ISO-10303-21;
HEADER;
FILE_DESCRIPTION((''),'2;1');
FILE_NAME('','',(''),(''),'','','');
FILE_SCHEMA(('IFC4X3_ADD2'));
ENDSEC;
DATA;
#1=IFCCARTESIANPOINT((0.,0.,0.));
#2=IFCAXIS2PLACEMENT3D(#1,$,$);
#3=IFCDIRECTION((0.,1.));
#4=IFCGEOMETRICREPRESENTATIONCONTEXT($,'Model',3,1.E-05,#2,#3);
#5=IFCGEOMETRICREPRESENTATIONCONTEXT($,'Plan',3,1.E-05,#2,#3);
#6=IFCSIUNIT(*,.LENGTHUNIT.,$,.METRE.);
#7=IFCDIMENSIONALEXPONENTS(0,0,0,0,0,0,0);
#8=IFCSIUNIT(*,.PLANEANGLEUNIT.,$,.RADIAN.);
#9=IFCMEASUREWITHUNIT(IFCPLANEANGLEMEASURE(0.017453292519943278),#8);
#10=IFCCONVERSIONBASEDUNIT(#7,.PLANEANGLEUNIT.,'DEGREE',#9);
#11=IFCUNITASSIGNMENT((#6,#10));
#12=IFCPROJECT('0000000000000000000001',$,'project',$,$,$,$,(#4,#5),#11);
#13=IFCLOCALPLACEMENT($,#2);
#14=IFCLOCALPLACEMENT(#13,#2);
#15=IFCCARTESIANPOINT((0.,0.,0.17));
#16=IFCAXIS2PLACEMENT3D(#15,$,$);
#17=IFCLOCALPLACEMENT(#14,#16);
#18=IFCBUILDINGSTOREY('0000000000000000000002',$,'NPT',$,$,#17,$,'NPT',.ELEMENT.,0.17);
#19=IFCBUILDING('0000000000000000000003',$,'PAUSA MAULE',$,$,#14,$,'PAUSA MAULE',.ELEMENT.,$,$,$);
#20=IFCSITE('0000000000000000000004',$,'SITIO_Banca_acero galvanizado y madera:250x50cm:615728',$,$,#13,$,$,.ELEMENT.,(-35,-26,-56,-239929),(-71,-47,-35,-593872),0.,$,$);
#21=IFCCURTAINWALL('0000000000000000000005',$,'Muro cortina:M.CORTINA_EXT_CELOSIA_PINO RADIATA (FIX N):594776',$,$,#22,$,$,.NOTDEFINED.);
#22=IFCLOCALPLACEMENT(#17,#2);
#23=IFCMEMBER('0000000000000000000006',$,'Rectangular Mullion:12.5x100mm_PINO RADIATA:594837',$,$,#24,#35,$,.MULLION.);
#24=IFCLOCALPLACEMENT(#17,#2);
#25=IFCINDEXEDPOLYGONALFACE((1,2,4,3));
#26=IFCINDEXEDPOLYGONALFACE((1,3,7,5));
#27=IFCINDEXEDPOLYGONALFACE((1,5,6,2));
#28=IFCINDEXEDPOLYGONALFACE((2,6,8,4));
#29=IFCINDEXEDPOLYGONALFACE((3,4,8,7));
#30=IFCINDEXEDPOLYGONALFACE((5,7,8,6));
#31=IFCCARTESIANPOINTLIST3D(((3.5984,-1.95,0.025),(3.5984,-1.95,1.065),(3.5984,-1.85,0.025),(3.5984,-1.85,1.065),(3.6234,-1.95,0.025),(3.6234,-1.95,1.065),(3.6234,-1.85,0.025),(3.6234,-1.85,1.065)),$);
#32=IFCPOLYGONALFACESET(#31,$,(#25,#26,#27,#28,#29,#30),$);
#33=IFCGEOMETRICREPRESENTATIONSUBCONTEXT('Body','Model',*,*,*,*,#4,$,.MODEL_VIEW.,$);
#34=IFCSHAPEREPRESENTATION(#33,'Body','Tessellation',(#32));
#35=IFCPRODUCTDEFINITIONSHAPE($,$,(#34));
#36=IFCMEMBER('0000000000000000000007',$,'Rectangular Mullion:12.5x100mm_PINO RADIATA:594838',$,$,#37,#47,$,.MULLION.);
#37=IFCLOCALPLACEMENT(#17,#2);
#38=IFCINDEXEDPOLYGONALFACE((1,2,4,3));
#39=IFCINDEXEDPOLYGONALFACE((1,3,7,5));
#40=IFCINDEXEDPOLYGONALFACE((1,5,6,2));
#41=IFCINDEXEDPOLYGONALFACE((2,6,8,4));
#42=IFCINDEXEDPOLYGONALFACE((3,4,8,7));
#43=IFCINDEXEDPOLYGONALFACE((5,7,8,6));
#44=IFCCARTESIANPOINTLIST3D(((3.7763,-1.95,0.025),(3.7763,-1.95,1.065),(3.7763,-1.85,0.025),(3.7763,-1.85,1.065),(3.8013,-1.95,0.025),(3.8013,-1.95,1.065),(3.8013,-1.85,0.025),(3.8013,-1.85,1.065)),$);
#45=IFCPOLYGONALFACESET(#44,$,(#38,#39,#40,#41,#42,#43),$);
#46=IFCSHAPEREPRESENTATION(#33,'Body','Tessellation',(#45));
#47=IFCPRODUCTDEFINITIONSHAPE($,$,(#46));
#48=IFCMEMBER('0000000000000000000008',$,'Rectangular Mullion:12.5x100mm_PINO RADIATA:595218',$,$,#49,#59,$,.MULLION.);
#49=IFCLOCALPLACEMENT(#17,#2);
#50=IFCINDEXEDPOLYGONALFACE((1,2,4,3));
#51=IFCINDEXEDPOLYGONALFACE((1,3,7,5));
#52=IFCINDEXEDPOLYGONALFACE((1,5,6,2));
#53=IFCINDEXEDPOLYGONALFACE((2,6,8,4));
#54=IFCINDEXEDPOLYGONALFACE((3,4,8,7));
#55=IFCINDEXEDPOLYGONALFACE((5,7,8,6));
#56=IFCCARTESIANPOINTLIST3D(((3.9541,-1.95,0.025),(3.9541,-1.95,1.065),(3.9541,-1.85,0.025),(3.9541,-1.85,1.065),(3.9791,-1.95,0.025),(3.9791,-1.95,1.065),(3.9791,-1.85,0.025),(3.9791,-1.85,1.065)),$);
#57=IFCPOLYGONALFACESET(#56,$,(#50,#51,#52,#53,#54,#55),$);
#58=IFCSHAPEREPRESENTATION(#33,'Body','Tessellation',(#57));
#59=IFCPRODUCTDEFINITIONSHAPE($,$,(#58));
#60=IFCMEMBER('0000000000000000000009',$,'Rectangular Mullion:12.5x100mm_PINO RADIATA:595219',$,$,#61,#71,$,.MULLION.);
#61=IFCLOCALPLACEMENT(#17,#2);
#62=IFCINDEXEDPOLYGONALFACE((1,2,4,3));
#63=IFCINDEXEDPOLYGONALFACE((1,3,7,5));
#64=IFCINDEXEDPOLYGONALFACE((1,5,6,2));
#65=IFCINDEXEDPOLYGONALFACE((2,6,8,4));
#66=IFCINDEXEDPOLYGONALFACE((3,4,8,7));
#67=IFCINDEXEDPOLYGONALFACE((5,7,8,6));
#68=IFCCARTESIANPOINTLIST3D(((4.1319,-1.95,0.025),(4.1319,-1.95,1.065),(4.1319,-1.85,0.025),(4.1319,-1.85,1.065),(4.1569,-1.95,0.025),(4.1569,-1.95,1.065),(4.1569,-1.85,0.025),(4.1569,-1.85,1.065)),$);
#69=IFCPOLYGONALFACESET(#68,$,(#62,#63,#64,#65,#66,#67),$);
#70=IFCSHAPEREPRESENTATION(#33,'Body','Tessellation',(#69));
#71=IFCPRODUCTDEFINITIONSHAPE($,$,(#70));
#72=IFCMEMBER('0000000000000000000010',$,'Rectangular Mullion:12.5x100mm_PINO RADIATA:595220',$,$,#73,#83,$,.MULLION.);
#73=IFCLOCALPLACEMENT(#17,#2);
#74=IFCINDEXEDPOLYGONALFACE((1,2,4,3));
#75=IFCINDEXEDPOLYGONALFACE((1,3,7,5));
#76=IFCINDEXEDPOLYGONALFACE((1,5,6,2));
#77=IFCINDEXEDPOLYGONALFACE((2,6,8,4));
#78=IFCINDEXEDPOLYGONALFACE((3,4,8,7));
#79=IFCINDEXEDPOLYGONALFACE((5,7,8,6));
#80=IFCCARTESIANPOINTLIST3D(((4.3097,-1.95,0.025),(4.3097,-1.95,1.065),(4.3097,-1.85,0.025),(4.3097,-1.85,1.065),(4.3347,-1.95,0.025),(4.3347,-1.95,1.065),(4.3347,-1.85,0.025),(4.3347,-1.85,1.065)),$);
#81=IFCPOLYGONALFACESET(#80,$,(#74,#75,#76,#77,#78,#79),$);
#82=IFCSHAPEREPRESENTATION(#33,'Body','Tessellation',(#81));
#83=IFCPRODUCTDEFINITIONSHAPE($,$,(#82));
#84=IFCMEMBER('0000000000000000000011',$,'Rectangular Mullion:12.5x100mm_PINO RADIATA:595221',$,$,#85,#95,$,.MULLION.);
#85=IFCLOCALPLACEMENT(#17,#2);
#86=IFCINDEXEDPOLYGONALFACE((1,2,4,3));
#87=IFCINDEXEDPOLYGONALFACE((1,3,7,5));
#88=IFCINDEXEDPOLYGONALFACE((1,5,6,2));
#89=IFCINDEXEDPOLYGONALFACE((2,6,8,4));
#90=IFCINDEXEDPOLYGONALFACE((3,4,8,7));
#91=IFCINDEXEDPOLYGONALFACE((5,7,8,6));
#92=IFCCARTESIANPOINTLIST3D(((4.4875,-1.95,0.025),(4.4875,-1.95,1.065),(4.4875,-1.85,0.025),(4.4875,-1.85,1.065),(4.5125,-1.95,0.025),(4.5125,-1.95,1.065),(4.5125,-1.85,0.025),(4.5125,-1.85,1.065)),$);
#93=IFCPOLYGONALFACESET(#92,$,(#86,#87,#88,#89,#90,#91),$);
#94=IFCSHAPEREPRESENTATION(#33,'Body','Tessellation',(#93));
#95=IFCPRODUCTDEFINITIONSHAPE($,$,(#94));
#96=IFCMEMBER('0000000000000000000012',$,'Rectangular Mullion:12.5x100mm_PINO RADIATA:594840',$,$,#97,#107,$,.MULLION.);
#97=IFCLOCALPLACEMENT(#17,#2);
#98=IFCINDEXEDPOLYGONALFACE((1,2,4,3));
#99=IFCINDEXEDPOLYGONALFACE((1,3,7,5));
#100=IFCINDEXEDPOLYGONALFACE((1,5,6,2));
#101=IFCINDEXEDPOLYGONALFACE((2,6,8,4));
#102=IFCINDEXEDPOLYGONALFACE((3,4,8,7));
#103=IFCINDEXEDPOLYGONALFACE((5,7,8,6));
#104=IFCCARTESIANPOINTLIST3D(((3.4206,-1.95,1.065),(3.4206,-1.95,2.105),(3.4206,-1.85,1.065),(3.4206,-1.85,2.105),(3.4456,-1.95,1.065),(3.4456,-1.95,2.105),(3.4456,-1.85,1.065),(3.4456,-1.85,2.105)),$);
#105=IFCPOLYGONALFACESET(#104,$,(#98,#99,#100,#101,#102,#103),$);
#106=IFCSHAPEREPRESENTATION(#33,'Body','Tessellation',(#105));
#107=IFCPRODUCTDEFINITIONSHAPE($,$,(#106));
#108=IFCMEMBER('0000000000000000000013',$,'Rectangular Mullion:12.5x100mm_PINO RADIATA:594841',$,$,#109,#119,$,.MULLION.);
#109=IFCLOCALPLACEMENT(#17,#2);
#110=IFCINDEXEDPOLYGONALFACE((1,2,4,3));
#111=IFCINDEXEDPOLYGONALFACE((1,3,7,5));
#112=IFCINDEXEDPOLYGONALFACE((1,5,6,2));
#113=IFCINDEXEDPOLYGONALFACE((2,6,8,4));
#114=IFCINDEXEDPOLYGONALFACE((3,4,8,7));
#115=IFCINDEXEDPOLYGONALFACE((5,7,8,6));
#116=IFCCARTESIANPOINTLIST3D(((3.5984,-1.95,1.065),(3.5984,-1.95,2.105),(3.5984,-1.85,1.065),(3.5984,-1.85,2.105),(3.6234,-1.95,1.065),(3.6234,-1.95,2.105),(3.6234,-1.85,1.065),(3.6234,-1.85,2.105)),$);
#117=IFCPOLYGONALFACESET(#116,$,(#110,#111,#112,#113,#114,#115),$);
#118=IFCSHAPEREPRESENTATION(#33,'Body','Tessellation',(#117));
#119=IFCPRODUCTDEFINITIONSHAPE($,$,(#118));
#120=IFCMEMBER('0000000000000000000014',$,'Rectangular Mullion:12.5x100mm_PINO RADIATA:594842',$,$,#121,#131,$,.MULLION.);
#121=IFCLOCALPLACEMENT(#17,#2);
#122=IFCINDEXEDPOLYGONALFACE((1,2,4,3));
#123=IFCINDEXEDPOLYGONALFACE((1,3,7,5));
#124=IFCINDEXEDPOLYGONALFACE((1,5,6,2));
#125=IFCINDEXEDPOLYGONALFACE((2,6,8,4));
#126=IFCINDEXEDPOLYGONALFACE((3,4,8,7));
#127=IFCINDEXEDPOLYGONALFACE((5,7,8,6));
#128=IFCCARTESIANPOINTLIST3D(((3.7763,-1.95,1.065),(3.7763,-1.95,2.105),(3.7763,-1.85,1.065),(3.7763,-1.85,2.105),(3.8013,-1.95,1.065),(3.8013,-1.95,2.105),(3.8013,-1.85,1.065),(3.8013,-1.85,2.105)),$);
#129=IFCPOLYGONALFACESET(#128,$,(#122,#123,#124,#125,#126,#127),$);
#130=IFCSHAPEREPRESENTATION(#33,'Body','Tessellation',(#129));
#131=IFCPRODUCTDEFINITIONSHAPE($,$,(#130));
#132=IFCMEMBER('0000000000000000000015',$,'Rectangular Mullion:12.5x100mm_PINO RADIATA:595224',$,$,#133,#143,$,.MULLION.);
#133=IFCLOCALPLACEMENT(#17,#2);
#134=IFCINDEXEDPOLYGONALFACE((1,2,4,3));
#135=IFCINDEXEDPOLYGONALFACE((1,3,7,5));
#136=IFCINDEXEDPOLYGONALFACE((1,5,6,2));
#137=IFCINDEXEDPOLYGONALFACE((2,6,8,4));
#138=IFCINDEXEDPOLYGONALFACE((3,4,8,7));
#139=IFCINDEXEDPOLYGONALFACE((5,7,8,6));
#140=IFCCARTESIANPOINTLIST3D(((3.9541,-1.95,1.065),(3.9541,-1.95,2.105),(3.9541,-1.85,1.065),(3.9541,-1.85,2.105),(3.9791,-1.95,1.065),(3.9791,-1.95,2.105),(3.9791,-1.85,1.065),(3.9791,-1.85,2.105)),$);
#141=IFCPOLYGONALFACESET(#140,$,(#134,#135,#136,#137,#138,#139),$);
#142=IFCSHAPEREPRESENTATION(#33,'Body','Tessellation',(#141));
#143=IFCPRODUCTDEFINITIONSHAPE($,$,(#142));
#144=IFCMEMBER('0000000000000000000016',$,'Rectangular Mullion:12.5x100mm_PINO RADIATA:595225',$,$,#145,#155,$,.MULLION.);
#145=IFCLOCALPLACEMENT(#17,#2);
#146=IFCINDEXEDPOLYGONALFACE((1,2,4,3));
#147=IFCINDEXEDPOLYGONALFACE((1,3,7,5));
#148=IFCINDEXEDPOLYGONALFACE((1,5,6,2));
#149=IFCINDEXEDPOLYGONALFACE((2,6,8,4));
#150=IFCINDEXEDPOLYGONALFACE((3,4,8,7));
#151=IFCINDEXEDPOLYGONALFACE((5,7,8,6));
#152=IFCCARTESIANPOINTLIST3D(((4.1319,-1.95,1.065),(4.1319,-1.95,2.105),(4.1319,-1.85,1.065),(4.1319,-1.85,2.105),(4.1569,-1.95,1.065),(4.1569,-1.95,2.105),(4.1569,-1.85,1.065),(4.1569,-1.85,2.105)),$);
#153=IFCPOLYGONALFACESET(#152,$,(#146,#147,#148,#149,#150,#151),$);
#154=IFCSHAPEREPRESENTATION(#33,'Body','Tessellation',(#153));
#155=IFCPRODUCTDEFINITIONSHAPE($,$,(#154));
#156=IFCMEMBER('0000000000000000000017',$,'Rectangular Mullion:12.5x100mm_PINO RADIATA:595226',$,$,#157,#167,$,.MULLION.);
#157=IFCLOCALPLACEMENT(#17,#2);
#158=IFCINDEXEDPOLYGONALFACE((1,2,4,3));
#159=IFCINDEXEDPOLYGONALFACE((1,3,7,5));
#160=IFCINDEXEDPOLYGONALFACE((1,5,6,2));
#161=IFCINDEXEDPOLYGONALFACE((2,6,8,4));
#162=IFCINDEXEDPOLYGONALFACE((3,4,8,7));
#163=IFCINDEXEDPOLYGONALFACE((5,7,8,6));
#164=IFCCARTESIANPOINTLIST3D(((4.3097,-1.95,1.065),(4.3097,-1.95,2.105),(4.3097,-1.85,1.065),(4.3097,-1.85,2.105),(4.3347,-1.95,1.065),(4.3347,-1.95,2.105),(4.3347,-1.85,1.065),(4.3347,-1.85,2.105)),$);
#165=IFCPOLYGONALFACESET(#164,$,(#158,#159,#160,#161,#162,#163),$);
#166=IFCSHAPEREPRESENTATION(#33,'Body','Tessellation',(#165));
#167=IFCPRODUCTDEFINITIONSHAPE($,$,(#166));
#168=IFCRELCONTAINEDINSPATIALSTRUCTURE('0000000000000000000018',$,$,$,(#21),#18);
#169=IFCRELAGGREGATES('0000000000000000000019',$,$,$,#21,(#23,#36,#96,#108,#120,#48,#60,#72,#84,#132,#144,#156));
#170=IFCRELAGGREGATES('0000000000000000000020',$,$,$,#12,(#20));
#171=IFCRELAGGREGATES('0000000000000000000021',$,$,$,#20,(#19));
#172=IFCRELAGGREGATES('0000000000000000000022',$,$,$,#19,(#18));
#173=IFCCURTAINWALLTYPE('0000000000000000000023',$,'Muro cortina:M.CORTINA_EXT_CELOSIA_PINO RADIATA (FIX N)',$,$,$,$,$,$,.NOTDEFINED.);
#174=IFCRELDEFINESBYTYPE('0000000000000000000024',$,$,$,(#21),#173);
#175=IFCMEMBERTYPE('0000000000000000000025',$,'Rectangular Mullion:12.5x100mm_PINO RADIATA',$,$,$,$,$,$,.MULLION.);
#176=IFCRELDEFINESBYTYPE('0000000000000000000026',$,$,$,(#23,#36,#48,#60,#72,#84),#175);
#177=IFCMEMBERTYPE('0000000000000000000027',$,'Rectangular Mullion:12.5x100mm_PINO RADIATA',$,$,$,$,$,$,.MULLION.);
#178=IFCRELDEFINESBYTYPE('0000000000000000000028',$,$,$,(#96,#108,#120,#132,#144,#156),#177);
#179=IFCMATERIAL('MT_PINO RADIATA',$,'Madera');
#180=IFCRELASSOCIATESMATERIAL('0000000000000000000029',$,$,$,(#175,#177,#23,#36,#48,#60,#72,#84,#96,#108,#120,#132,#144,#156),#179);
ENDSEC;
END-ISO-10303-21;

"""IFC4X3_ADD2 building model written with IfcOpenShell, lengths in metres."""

from ifc_helpers import new_model, entity, si_unit, converted_unit, direction, frame, frame_2d, origin, origin_2d_with_axis, place, context, subcontext, project, spatial, rectangle, extrude, source, transform, mapped, material, material_profile, profile_set, profile_usage, type_object, type_shapes, element, aggregate, save


model = new_model("IFC4X3_ADD2")

# Units and contexts
model_context = context("Model", 3, precision=1e-05, world=origin(), true_north=direction((0.0, 1.0)))
plan_context = context("Plan", 3, precision=1e-05, world=origin(), true_north=direction((0.0, 1.0)))
body_context = subcontext(model_context, "Body", "Model", "MODEL_VIEW")
ifc_project = project(units=[si_unit("LENGTHUNIT", "METRE"), converted_unit("PLANEANGLEUNIT", "DEGREE", entity("IfcPlaneAngleMeasure", 0.017453292519943278), si_unit("PLANEANGLEUNIT", "RADIAN"), dimensions=[0, 0, 0, 0, 0, 0, 0])], contexts=[model_context, plan_context])

# Site, building, storey
site_placement = place(None, origin())
site = spatial("IfcSite", under=ifc_project, at=site_placement, Name="SITIO_Banca_acero galvanizado y madera:250x50cm:615728", CompositionType="ELEMENT", RefLatitude=(-35, -26, -56, -239929), RefLongitude=(-71, -47, -35, -593872), RefElevation=0.0)
building_placement = place(site_placement, origin())
building = spatial("IfcBuilding", under=site, at=building_placement, Name="PAUSA MAULE", LongName="PAUSA MAULE", CompositionType="ELEMENT")
storey_placement = place(building_placement, frame((0.0, 0.0, 0.17)))
storey = spatial("IfcBuildingStorey", under=building, at=storey_placement, Name="NPT", LongName="NPT", CompositionType="ELEMENT", Elevation=0.17)

# Curtain wall, members
curtain_wall_type = type_object("IfcCurtainWallType", Name="Muro cortina:M.CORTINA_EXT_CELOSIA_PINO RADIATA (FIX N)", PredefinedType="NOTDEFINED")
curtain_wall_placement = place(storey_placement, frame((0.0, 0.0, -0.17)))
curtain_wall = element("IfcCurtainWall", 1, at=curtain_wall_placement, inside=storey, type_object=curtain_wall_type, Name="Muro cortina:M.CORTINA_EXT_CELOSIA_PINO RADIATA (FIX N):594776", PredefinedType="NOTDEFINED")
ifc_material = material(Name="MT_PINO RADIATA", Category="Madera")
ifc_material_profile = material_profile(ifc_material, rectangle(XDim=0.025, YDim=0.1, at=frame_2d((0.0, 0.0), x_axis=(1.0, 0.0))), Name="12.5x100mm_PINO RADIATA")
ifc_profile_set = profile_set([ifc_material_profile], Name="12.5x100mm_PINO RADIATA")
ifc_profile_usage = profile_usage(ifc_profile_set)
member_type_1 = type_object("IfcMemberType", Name="Rectangular Mullion:12.5x100mm_PINO RADIATA", PredefinedType="MULLION", material=ifc_profile_set)
shared_shape_1 = source(origin(), body_context, "Body", "SweptSolid", [
    extrude(rectangle(XDim=0.025, YDim=0.1, at=frame_2d((0.0, 0.0), x_axis=(1.0, 0.0))), frame((0.0, 0.0, -1.04), z_axis=(0.0, 0.0, 1.0), x_axis=(-1.0, 0.0, 0.0)), (0.0, 0.0, 1.0), 1.04),
])
type_shapes(member_type_1, [shared_shape_1])
member_1_placement = place(curtain_wall_placement, frame((3.6109, -1.9, 0.195), z_axis=(0.0, 0.0, -1.0), x_axis=(1.0, 0.0, 0.0)))
member_1 = element("IfcMember", 2, at=member_1_placement, type_object=member_type_1, material=ifc_profile_usage, Name="Rectangular Mullion:12.5x100mm_PINO RADIATA:594837", PredefinedType="MULLION", context=body_context, shape_type="MappedRepresentation", body=[
    mapped(shared_shape_1, transform((0.0, 0.0, 0.0), scale=1.0)),
])
member_2_placement = place(curtain_wall_placement, frame((3.7888, -1.9, 0.195), z_axis=(0.0, 0.0, -1.0), x_axis=(1.0, 0.0, 0.0)))
member_2 = element("IfcMember", 3, at=member_2_placement, type_object=member_type_1, material=ifc_profile_usage, Name="Rectangular Mullion:12.5x100mm_PINO RADIATA:594838", PredefinedType="MULLION", context=body_context, shape_type="MappedRepresentation", body=[
    mapped(shared_shape_1, transform((0.0, 0.0, 0.0), scale=1.0)),
])
member_3_placement = place(curtain_wall_placement, frame((3.9666, -1.9, 0.195), z_axis=(0.0, 0.0, -1.0), x_axis=(1.0, 0.0, 0.0)))
member_3 = element("IfcMember", 4, at=member_3_placement, type_object=member_type_1, material=ifc_profile_usage, Name="Rectangular Mullion:12.5x100mm_PINO RADIATA:595218", PredefinedType="MULLION", context=body_context, shape_type="MappedRepresentation", body=[
    mapped(shared_shape_1, transform((0.0, 0.0, 0.0), scale=1.0)),
])
member_4_placement = place(curtain_wall_placement, frame((4.1444, -1.9, 0.195), z_axis=(0.0, 0.0, -1.0), x_axis=(1.0, 0.0, 0.0)))
member_4 = element("IfcMember", 5, at=member_4_placement, type_object=member_type_1, material=ifc_profile_usage, Name="Rectangular Mullion:12.5x100mm_PINO RADIATA:595219", PredefinedType="MULLION", context=body_context, shape_type="MappedRepresentation", body=[
    mapped(shared_shape_1, transform((0.0, 0.0, 0.0), scale=1.0)),
])
member_5_placement = place(curtain_wall_placement, frame((4.3222, -1.9, 0.195), z_axis=(0.0, 0.0, -1.0), x_axis=(1.0, 0.0, 0.0)))
member_5 = element("IfcMember", 6, at=member_5_placement, type_object=member_type_1, material=ifc_profile_usage, Name="Rectangular Mullion:12.5x100mm_PINO RADIATA:595220", PredefinedType="MULLION", context=body_context, shape_type="MappedRepresentation", body=[
    mapped(shared_shape_1, transform((0.0, 0.0, 0.0), scale=1.0)),
])
member_6_placement = place(curtain_wall_placement, frame((4.5, -1.9, 0.195), z_axis=(0.0, 0.0, -1.0), x_axis=(1.0, 0.0, 0.0)))
member_6 = element("IfcMember", 7, at=member_6_placement, type_object=member_type_1, material=ifc_profile_usage, Name="Rectangular Mullion:12.5x100mm_PINO RADIATA:595221", PredefinedType="MULLION", context=body_context, shape_type="MappedRepresentation", body=[
    mapped(shared_shape_1, transform((0.0, 0.0, 0.0), scale=1.0)),
])
member_type_2 = type_object("IfcMemberType", Name="Rectangular Mullion:12.5x100mm_PINO RADIATA", PredefinedType="MULLION", material=ifc_profile_set)
shared_shape_2 = source(origin(), body_context, "Body", "SweptSolid", [
    extrude(rectangle(XDim=0.025, YDim=0.1, at=origin_2d_with_axis()), frame((0.0, 0.0, -1.04), z_axis=(0.0, 0.0, 1.0), x_axis=(-1.0, 0.0, 0.0)), (0.0, 0.0, 1.0), 1.04),
])
type_shapes(member_type_2, [shared_shape_2])
member_7_placement = place(curtain_wall_placement, frame((3.4331, -1.9, 1.235), z_axis=(0.0, 0.0, -1.0), x_axis=(1.0, 0.0, 0.0)))
member_7 = element("IfcMember", 8, at=member_7_placement, type_object=member_type_2, material=ifc_profile_usage, Name="Rectangular Mullion:12.5x100mm_PINO RADIATA:594840", PredefinedType="MULLION", context=body_context, shape_type="MappedRepresentation", body=[
    mapped(shared_shape_2, transform((0.0, 0.0, 0.0), scale=1.0)),
])
member_8_placement = place(curtain_wall_placement, frame((3.6109, -1.9, 1.235), z_axis=(0.0, 0.0, -1.0), x_axis=(1.0, 0.0, 0.0)))
member_8 = element("IfcMember", 9, at=member_8_placement, type_object=member_type_2, material=ifc_profile_usage, Name="Rectangular Mullion:12.5x100mm_PINO RADIATA:594841", PredefinedType="MULLION", context=body_context, shape_type="MappedRepresentation", body=[
    mapped(shared_shape_2, transform((0.0, 0.0, 0.0), scale=1.0)),
])
member_9_placement = place(curtain_wall_placement, frame((3.7888, -1.9, 1.235), z_axis=(0.0, 0.0, -1.0), x_axis=(1.0, 0.0, 0.0)))
member_9 = element("IfcMember", 10, at=member_9_placement, type_object=member_type_2, material=ifc_profile_usage, Name="Rectangular Mullion:12.5x100mm_PINO RADIATA:594842", PredefinedType="MULLION", context=body_context, shape_type="MappedRepresentation", body=[
    mapped(shared_shape_2, transform((0.0, 0.0, 0.0), scale=1.0)),
])
member_10_placement = place(curtain_wall_placement, frame((3.9666, -1.9, 1.235), z_axis=(0.0, 0.0, -1.0), x_axis=(1.0, 0.0, 0.0)))
member_10 = element("IfcMember", 11, at=member_10_placement, type_object=member_type_2, material=ifc_profile_usage, Name="Rectangular Mullion:12.5x100mm_PINO RADIATA:595224", PredefinedType="MULLION", context=body_context, shape_type="MappedRepresentation", body=[
    mapped(shared_shape_2, transform((0.0, 0.0, 0.0), scale=1.0)),
])
member_11_placement = place(curtain_wall_placement, frame((4.1444, -1.9, 1.235), z_axis=(0.0, 0.0, -1.0), x_axis=(1.0, 0.0, 0.0)))
member_11 = element("IfcMember", 12, at=member_11_placement, type_object=member_type_2, material=ifc_profile_usage, Name="Rectangular Mullion:12.5x100mm_PINO RADIATA:595225", PredefinedType="MULLION", context=body_context, shape_type="MappedRepresentation", body=[
    mapped(shared_shape_2, transform((0.0, 0.0, 0.0), scale=1.0)),
])
member_12_placement = place(curtain_wall_placement, frame((4.3222, -1.9, 1.235), z_axis=(0.0, 0.0, -1.0), x_axis=(1.0, 0.0, 0.0)))
member_12 = element("IfcMember", 13, at=member_12_placement, type_object=member_type_2, material=ifc_profile_usage, Name="Rectangular Mullion:12.5x100mm_PINO RADIATA:595226", PredefinedType="MULLION", context=body_context, shape_type="MappedRepresentation", body=[
    mapped(shared_shape_2, transform((0.0, 0.0, 0.0), scale=1.0)),
])
aggregate(curtain_wall, [member_1, member_2, member_7, member_8, member_9, member_3, member_4, member_5, member_6, member_10, member_11, member_12])

save(model, "model.ifc")
